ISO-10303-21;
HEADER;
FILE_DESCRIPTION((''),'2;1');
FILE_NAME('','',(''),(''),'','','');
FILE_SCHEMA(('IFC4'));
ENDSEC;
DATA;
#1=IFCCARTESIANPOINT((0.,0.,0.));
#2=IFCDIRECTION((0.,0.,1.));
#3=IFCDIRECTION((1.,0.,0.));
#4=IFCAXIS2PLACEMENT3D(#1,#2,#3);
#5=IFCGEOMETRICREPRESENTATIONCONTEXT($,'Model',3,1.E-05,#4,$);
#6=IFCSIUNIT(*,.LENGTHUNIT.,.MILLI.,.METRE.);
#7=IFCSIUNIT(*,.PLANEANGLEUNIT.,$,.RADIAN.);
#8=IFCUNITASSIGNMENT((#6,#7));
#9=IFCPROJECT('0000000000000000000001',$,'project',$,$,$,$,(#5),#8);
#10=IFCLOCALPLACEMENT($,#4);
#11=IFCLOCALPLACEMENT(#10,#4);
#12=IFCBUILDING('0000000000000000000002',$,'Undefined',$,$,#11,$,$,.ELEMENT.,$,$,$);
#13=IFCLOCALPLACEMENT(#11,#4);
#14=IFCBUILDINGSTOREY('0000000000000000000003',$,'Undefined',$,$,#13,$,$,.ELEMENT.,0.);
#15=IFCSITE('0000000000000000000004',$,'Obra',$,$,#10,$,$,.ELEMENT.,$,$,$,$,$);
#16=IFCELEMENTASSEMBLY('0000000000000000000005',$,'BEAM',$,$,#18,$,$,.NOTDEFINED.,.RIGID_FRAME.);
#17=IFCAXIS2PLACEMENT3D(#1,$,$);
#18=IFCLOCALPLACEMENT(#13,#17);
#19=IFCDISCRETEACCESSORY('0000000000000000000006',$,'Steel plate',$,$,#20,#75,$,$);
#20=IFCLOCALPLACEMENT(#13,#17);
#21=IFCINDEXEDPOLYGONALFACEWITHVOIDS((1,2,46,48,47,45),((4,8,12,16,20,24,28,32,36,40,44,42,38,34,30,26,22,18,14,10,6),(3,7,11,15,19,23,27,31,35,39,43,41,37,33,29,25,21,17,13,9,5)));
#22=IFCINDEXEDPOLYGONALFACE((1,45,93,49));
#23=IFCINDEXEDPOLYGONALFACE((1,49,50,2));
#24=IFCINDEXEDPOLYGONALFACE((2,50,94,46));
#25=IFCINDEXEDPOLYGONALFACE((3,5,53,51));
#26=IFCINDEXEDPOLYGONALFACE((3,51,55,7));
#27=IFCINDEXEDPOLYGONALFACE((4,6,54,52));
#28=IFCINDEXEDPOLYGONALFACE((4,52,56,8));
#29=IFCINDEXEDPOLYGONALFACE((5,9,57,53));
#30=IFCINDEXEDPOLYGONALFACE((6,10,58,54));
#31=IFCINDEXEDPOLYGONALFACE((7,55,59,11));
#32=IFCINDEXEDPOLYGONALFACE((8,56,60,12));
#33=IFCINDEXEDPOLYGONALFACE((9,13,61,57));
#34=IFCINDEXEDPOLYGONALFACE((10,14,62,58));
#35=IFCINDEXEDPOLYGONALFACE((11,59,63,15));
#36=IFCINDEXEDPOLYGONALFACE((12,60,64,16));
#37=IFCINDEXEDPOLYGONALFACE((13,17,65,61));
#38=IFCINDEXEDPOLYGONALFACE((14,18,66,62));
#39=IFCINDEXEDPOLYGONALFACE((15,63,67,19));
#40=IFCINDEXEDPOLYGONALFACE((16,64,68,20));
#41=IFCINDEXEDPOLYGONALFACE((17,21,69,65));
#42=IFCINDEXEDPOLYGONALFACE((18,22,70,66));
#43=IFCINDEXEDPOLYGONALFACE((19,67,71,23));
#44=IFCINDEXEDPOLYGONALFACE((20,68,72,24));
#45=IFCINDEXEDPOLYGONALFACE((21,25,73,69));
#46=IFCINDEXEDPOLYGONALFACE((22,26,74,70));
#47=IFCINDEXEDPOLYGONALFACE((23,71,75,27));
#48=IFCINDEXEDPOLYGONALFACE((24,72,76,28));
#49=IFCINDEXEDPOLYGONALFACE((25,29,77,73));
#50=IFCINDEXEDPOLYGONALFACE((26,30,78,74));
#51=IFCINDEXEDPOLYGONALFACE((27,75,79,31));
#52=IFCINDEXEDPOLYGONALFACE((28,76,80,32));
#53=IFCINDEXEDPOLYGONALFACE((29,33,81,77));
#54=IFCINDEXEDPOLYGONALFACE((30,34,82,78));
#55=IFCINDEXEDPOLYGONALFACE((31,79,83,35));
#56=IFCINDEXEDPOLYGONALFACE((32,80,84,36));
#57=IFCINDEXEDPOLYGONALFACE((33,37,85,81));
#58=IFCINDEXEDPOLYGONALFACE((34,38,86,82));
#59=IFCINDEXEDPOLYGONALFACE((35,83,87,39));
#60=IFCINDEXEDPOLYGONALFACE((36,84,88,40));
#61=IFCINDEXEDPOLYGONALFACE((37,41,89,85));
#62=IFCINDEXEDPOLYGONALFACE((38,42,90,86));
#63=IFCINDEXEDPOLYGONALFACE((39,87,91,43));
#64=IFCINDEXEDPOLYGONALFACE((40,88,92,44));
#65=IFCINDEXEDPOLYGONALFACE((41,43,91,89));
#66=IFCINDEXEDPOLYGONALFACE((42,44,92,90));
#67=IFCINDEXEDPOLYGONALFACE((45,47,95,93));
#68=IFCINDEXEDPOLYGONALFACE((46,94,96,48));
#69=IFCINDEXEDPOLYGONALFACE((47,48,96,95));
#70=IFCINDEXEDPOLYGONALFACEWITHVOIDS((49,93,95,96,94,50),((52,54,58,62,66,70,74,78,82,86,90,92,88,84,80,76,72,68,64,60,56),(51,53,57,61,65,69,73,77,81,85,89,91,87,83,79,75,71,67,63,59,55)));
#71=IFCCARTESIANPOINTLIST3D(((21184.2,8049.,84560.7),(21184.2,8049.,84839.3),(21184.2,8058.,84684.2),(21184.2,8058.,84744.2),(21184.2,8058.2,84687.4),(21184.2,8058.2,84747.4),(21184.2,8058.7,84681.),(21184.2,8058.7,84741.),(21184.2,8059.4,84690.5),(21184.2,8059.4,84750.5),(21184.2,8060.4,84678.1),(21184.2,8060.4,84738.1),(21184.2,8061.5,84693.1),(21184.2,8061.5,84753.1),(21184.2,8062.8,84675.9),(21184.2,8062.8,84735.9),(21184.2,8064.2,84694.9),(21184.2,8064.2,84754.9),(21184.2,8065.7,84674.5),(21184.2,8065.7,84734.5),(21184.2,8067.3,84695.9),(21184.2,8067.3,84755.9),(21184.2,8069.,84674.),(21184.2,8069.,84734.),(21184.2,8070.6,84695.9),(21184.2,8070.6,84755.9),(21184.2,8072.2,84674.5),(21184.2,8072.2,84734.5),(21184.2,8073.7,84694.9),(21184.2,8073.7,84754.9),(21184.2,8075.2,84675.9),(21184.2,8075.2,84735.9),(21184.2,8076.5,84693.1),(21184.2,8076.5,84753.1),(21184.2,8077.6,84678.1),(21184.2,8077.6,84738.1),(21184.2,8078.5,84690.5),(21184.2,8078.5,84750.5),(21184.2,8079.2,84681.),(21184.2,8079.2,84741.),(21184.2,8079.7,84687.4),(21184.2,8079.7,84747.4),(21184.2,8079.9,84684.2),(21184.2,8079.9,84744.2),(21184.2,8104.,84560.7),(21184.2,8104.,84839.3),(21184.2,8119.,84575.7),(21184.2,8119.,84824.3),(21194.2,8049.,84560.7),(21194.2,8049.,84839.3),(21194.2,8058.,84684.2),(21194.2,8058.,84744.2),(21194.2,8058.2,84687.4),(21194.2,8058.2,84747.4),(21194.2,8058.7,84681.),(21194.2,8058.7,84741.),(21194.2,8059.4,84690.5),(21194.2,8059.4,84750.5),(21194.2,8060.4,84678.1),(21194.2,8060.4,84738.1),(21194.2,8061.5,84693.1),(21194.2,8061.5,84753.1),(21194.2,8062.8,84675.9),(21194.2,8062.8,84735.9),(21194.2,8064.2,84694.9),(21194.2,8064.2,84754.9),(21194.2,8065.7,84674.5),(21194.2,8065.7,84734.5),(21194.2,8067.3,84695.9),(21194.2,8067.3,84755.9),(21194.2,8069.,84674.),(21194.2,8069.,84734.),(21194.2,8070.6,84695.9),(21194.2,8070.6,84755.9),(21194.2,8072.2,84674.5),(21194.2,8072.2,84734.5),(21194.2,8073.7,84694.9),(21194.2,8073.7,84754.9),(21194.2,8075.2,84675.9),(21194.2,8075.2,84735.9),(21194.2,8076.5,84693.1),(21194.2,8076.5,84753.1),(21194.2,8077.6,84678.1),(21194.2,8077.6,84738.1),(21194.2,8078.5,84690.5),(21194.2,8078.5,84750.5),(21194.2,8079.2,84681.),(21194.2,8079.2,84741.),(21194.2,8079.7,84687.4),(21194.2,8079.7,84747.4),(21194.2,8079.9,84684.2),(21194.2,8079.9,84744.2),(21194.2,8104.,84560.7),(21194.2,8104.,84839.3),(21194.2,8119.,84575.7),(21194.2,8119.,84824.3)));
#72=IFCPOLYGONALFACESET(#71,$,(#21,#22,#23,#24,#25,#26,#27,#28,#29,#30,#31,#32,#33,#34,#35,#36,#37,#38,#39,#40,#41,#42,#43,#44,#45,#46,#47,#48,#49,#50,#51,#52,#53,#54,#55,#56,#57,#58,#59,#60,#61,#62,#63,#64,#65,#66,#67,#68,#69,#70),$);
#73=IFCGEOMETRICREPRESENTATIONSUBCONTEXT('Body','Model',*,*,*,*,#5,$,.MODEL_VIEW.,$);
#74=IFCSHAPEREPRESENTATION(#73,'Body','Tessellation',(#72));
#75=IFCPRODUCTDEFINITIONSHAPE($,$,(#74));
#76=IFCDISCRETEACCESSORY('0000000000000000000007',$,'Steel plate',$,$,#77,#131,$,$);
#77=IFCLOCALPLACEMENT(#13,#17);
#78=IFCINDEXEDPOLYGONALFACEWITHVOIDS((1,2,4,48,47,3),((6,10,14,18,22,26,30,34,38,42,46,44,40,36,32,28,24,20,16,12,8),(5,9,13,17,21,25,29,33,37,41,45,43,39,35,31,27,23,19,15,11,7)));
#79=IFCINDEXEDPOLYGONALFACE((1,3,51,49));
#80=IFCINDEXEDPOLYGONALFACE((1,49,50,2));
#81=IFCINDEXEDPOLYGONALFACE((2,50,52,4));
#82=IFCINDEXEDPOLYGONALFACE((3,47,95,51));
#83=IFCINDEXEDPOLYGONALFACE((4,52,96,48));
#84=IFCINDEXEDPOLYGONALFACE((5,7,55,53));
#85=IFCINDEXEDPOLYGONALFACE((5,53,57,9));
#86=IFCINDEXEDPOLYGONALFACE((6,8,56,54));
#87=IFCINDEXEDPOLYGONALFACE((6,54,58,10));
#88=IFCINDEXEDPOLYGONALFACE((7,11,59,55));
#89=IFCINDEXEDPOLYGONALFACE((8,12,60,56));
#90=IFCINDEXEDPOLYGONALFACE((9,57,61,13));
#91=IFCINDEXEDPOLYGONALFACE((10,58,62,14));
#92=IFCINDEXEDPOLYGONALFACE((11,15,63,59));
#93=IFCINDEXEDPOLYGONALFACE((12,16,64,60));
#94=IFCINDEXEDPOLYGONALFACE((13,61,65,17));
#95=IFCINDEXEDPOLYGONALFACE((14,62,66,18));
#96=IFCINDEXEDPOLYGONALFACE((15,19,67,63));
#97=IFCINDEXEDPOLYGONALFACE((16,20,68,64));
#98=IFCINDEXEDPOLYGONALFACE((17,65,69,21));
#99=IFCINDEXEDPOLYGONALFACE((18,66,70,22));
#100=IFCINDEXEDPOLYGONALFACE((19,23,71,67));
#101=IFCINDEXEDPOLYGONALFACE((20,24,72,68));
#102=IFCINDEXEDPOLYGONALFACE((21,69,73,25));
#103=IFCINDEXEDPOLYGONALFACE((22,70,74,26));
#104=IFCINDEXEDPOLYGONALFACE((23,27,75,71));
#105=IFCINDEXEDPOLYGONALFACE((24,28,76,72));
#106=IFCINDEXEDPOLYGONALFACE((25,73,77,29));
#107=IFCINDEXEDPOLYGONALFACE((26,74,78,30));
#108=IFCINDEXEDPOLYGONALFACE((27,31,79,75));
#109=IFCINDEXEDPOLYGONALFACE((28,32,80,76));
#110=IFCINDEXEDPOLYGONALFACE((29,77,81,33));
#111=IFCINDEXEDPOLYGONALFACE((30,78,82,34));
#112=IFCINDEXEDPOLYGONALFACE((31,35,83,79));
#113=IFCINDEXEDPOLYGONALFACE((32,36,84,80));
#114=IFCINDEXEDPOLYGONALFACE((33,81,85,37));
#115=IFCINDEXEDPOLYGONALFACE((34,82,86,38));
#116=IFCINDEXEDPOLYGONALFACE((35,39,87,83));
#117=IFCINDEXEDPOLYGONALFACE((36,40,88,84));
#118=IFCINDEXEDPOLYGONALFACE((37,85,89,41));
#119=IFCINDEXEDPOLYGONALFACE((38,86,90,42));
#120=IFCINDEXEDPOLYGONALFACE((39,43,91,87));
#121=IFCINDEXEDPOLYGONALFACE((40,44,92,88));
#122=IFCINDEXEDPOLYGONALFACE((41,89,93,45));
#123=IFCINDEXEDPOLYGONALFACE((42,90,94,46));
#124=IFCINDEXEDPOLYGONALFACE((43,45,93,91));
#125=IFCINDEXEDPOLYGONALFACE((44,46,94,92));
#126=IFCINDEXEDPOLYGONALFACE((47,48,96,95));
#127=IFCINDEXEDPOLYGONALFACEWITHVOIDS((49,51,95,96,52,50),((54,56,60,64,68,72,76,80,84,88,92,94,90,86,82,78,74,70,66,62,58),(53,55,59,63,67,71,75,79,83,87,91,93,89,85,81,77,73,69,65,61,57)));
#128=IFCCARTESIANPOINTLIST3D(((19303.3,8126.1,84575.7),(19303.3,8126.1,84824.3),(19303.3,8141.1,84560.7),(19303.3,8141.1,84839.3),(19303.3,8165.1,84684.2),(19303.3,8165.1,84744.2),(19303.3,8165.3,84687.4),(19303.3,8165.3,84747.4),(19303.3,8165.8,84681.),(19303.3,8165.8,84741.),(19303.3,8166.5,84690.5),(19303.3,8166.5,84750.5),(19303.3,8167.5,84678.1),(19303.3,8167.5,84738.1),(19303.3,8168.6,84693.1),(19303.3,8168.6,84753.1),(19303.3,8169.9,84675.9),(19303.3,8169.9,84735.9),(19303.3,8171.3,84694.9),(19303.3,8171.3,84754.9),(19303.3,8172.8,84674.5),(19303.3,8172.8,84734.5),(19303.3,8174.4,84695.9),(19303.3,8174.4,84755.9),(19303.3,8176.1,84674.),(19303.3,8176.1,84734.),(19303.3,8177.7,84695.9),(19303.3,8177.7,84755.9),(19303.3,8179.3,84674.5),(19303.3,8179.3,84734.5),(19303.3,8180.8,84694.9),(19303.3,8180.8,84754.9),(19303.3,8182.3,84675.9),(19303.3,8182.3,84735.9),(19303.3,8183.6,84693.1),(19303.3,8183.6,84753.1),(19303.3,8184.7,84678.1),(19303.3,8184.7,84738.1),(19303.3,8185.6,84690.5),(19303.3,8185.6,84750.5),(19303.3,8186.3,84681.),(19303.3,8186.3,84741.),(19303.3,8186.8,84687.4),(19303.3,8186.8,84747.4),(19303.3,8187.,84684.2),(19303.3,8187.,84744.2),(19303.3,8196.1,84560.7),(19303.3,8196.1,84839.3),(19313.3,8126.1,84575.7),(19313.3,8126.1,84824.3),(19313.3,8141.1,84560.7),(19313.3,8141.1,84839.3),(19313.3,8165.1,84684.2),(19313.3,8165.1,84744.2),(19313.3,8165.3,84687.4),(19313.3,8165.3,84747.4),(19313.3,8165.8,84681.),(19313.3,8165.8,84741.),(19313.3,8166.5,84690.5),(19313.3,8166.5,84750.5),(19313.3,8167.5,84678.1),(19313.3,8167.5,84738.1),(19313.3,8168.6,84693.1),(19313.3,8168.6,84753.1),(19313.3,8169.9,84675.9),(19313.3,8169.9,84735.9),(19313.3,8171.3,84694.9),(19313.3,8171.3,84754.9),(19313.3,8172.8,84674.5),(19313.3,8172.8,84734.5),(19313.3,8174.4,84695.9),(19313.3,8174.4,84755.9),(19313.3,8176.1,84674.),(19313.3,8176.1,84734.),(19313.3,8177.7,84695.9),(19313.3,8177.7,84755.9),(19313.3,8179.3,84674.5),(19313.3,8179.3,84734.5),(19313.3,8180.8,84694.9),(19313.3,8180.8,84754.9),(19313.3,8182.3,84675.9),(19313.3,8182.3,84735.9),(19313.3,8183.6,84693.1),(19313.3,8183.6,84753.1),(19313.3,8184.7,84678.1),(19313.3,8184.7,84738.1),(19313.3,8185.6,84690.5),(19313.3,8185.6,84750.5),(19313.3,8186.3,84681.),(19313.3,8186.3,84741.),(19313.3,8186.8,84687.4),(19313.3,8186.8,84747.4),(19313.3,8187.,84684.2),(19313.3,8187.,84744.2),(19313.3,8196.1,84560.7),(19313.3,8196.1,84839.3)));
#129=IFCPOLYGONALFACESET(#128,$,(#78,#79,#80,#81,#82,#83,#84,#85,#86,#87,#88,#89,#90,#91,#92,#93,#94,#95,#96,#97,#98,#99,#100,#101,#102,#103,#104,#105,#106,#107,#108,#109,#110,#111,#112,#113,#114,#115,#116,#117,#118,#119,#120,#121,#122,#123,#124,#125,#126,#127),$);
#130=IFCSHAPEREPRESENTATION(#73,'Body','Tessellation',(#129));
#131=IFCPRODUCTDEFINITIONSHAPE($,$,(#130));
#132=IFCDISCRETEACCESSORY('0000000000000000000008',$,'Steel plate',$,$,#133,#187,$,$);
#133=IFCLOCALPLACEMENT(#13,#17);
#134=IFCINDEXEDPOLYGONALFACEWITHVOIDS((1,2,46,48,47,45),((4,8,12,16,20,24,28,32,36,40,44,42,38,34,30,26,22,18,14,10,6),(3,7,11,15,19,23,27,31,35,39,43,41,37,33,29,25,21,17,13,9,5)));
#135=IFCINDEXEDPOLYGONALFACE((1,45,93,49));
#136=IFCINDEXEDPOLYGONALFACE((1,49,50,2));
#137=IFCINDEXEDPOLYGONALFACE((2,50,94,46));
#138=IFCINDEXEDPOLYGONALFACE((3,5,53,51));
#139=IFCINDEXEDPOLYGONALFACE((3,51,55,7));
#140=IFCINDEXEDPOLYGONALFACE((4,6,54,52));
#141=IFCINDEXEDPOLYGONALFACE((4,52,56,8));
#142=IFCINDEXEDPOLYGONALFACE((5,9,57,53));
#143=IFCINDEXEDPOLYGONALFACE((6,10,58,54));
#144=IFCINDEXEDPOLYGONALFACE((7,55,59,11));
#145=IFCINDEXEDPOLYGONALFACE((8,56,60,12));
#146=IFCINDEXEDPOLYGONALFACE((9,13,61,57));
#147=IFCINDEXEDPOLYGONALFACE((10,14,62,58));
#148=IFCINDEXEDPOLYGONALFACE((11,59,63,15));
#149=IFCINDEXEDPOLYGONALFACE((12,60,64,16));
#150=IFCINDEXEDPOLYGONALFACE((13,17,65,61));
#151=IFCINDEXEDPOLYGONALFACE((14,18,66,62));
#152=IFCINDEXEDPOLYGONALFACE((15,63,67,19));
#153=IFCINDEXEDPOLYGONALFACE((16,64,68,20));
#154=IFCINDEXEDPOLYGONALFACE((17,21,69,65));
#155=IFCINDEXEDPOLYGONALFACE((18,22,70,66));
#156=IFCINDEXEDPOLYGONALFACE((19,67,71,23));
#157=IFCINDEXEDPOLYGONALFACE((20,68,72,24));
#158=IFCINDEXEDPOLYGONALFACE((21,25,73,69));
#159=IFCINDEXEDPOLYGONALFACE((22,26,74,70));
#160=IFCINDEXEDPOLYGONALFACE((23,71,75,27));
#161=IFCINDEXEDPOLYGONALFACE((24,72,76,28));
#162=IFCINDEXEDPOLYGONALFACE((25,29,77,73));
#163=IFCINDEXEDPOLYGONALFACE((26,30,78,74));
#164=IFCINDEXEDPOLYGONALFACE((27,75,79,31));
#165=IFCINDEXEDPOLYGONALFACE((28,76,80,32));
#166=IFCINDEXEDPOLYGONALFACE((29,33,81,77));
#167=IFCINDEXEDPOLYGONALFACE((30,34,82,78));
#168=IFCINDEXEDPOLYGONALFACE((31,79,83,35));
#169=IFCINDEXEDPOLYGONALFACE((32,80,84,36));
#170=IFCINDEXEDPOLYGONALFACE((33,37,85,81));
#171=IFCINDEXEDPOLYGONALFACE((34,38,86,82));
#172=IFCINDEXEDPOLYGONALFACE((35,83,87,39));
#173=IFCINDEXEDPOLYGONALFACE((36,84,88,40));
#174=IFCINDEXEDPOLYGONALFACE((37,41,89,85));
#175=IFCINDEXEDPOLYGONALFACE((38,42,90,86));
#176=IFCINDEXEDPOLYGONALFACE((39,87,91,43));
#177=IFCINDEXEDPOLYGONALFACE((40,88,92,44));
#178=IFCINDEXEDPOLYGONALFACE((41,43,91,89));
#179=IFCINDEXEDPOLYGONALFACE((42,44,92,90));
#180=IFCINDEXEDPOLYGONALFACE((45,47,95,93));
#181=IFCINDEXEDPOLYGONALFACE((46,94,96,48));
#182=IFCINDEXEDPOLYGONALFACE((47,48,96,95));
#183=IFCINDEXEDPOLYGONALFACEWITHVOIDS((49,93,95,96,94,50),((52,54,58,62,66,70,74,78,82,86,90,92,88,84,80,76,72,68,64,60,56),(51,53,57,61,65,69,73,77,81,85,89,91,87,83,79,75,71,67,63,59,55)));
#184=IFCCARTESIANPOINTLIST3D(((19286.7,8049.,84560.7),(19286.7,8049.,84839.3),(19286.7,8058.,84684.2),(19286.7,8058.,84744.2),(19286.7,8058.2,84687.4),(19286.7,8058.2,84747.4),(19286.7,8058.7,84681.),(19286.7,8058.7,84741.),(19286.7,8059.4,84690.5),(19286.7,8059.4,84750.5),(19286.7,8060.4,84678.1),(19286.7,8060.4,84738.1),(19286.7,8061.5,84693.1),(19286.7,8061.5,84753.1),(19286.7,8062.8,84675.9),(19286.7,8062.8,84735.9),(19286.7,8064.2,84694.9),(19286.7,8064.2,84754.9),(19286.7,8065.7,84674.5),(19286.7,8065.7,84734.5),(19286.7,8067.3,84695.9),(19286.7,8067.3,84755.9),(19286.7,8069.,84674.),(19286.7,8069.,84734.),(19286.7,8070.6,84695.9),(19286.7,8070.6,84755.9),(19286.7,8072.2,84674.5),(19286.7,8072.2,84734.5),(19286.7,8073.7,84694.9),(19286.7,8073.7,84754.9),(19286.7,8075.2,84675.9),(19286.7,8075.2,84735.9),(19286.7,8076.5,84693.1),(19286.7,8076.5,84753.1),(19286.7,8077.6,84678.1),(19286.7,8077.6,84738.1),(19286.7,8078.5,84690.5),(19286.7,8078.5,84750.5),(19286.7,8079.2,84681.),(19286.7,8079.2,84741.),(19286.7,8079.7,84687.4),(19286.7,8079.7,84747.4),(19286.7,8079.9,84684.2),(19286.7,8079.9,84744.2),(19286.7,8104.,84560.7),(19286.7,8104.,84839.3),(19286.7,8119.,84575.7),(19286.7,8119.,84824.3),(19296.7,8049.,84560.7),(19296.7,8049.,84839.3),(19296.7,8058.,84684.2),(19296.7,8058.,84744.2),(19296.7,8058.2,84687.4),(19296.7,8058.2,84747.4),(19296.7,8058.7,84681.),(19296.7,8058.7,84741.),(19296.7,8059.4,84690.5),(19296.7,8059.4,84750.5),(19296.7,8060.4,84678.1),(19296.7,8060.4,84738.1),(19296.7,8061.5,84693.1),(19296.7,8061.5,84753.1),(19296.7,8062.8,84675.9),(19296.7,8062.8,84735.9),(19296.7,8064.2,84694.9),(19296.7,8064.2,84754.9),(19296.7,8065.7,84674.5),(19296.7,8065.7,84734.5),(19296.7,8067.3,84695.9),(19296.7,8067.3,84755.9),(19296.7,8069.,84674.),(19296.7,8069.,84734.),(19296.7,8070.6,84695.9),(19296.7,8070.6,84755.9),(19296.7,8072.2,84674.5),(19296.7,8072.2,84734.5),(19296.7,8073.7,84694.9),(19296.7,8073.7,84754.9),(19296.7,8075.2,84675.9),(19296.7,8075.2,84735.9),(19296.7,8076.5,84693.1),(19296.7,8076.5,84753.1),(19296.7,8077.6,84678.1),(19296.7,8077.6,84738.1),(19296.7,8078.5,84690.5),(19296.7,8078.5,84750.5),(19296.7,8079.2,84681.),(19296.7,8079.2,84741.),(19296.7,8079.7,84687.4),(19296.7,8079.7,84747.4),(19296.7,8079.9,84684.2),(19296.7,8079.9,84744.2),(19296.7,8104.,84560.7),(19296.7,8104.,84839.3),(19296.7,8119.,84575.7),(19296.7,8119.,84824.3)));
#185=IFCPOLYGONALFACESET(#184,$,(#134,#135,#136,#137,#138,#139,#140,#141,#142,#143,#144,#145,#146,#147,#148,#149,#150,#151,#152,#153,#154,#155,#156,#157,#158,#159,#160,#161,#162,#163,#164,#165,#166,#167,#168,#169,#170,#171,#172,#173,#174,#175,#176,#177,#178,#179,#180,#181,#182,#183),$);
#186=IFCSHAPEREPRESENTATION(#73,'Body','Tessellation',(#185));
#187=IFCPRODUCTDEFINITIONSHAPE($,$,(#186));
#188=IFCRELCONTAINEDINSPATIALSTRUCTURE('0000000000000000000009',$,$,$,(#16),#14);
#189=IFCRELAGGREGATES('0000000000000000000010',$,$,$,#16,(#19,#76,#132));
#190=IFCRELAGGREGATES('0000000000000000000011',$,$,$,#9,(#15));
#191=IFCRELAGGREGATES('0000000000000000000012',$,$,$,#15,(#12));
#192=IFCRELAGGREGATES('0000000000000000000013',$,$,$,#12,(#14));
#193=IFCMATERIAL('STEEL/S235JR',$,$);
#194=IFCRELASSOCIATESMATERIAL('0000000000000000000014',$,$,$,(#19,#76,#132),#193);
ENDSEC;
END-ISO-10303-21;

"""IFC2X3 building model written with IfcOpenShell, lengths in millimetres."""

from ifc_helpers import new_model, si_unit, frame, origin_with_axes, origin_2d_with_axis, place, context, subcontext, project, spatial, polyline, circle, outline, extrude, source, transform, mapped, material, element, aggregate, save


model = new_model("IFC2X3")

# Units and contexts
model_context = context("Model", 3, precision=1e-05, world=origin_with_axes())
body_context = subcontext(model_context, "Body", "Model", "MODEL_VIEW")
ifc_project = project(units=[si_unit("LENGTHUNIT", "METRE", prefix="MILLI"), si_unit("PLANEANGLEUNIT", "RADIAN")], contexts=[model_context])

# Site, building, storey
site_placement = place(None, origin_with_axes())
site = spatial("IfcSite", under=ifc_project, at=site_placement, Name="Obra", CompositionType="ELEMENT")
building_placement = place(site_placement, origin_with_axes())
building = spatial("IfcBuilding", under=site, at=building_placement, Name="Undefined", CompositionType="ELEMENT")
storey_placement = place(building_placement, origin_with_axes())
storey = spatial("IfcBuildingStorey", under=building, at=storey_placement, Name="Undefined", CompositionType="ELEMENT", Elevation=0.0)

# Shared definitions
ifc_material_1 = material(Name="STEEL/S235JR")

# Element assembly, discrete accessories, openings
assembly_1_placement = place(storey_placement, origin_with_axes())
assembly_1 = element("IfcElementAssembly", 1, at=assembly_1_placement, inside=storey, Name="BEAM", AssemblyPlace="NOTDEFINED", PredefinedType="RIGID_FRAME")
shared_shape_1 = source(origin_with_axes(), body_context, "Body", "SweptSolid", [
    extrude(circle(Radius=11.0, at=origin_2d_with_axis()), frame((0.0, -13.4, 0.0), z_axis=(0.0, 1.0, 0.0), x_axis=(1.0, 0.0, 0.0)), (0.0, 0.0, 1.0), 10.2),
])
discrete_accessory_1_placement = place(assembly_1_placement, frame((21189.2, 8049.0, 84560.7), z_axis=(1.0, 0.0, 0.0), x_axis=(0.0, 1.0, 0.0)))
discrete_accessory_1 = element("IfcDiscreteAccessory", 2, at=discrete_accessory_1_placement, material=ifc_material_1, Name="Steel plate", context=body_context, shape_type="SweptSolid", body=[
    extrude(outline(polyline([(0.0, 0.0), (55.0, 0.0), (70.0, 15.0), (70.0, 263.6), (55.0, 278.6), (0.0, 278.6), (0.0, 0.0)])), frame((0.0, 0.0, -5.0), z_axis=(0.0, 0.0, 1.0), x_axis=(1.0, 0.0, 0.0)), (0.0, 0.0, 1.0), 10.0),
])
opening_1_placement = place(assembly_1_placement, frame((21197.5, 8109.0, 84850.0), z_axis=(0.0, -1.0, 0.0), x_axis=(0.0, 0.0, -1.0)))
element("IfcOpeningElement", 3, at=opening_1_placement, cuts=discrete_accessory_1, ObjectType="Opening", context=body_context, shape_type="MappedRepresentation", body=[
    mapped(shared_shape_1, transform((105.0, 0.0, 40.0))),
    mapped(shared_shape_1, transform((165.0, 0.0, 40.0))),
])
discrete_accessory_2_placement = place(assembly_1_placement, frame((19308.3, 8196.1, 84560.7), z_axis=(-1.0, 0.0, 0.0), x_axis=(0.0, -1.0, 0.0)))
discrete_accessory_2 = element("IfcDiscreteAccessory", 4, at=discrete_accessory_2_placement, material=ifc_material_1, Name="Steel plate", context=body_context, shape_type="SweptSolid", body=[
    extrude(outline(polyline([(0.0, 0.0), (55.0, 0.0), (70.0, 15.0), (70.0, 263.6), (55.0, 278.6), (0.0, 278.6), (0.0, 0.0)])), frame((0.0, 0.0, -5.0), z_axis=(0.0, 0.0, 1.0), x_axis=(1.0, 0.0, 0.0)), (0.0, 0.0, 1.0), 10.0),
])
opening_2_placement = place(assembly_1_placement, frame((19300.0, 8136.1, 84850.0), z_axis=(0.0, 1.0, 0.0), x_axis=(0.0, 0.0, -1.0)))
element("IfcOpeningElement", 5, at=opening_2_placement, cuts=discrete_accessory_2, ObjectType="Opening", context=body_context, shape_type="MappedRepresentation", body=[
    mapped(shared_shape_1, transform((105.0, 0.0, 40.0))),
    mapped(shared_shape_1, transform((165.0, 0.0, 40.0))),
])
discrete_accessory_3_placement = place(assembly_1_placement, frame((19291.7, 8049.0, 84560.7), z_axis=(1.0, 0.0, 0.0), x_axis=(0.0, 1.0, 0.0)))
discrete_accessory_3 = element("IfcDiscreteAccessory", 6, at=discrete_accessory_3_placement, material=ifc_material_1, Name="Steel plate", context=body_context, shape_type="SweptSolid", body=[
    extrude(outline(polyline([(0.0, 0.0), (55.0, 0.0), (70.0, 15.0), (70.0, 263.6), (55.0, 278.6), (0.0, 278.6), (0.0, 0.0)])), frame((0.0, 0.0, -5.0), z_axis=(0.0, 0.0, 1.0), x_axis=(1.0, 0.0, 0.0)), (0.0, 0.0, 1.0), 10.0),
])
opening_3_placement = place(assembly_1_placement, frame((19300.0, 8109.0, 84850.0), z_axis=(0.0, -1.0, 0.0), x_axis=(0.0, 0.0, -1.0)))
element("IfcOpeningElement", 7, at=opening_3_placement, cuts=discrete_accessory_3, ObjectType="Opening", context=body_context, shape_type="MappedRepresentation", body=[
    mapped(shared_shape_1, transform((105.0, 0.0, 40.0))),
    mapped(shared_shape_1, transform((165.0, 0.0, 40.0))),
])
aggregate(assembly_1, [discrete_accessory_1, discrete_accessory_2, discrete_accessory_3])

save(model, "model.ifc")
